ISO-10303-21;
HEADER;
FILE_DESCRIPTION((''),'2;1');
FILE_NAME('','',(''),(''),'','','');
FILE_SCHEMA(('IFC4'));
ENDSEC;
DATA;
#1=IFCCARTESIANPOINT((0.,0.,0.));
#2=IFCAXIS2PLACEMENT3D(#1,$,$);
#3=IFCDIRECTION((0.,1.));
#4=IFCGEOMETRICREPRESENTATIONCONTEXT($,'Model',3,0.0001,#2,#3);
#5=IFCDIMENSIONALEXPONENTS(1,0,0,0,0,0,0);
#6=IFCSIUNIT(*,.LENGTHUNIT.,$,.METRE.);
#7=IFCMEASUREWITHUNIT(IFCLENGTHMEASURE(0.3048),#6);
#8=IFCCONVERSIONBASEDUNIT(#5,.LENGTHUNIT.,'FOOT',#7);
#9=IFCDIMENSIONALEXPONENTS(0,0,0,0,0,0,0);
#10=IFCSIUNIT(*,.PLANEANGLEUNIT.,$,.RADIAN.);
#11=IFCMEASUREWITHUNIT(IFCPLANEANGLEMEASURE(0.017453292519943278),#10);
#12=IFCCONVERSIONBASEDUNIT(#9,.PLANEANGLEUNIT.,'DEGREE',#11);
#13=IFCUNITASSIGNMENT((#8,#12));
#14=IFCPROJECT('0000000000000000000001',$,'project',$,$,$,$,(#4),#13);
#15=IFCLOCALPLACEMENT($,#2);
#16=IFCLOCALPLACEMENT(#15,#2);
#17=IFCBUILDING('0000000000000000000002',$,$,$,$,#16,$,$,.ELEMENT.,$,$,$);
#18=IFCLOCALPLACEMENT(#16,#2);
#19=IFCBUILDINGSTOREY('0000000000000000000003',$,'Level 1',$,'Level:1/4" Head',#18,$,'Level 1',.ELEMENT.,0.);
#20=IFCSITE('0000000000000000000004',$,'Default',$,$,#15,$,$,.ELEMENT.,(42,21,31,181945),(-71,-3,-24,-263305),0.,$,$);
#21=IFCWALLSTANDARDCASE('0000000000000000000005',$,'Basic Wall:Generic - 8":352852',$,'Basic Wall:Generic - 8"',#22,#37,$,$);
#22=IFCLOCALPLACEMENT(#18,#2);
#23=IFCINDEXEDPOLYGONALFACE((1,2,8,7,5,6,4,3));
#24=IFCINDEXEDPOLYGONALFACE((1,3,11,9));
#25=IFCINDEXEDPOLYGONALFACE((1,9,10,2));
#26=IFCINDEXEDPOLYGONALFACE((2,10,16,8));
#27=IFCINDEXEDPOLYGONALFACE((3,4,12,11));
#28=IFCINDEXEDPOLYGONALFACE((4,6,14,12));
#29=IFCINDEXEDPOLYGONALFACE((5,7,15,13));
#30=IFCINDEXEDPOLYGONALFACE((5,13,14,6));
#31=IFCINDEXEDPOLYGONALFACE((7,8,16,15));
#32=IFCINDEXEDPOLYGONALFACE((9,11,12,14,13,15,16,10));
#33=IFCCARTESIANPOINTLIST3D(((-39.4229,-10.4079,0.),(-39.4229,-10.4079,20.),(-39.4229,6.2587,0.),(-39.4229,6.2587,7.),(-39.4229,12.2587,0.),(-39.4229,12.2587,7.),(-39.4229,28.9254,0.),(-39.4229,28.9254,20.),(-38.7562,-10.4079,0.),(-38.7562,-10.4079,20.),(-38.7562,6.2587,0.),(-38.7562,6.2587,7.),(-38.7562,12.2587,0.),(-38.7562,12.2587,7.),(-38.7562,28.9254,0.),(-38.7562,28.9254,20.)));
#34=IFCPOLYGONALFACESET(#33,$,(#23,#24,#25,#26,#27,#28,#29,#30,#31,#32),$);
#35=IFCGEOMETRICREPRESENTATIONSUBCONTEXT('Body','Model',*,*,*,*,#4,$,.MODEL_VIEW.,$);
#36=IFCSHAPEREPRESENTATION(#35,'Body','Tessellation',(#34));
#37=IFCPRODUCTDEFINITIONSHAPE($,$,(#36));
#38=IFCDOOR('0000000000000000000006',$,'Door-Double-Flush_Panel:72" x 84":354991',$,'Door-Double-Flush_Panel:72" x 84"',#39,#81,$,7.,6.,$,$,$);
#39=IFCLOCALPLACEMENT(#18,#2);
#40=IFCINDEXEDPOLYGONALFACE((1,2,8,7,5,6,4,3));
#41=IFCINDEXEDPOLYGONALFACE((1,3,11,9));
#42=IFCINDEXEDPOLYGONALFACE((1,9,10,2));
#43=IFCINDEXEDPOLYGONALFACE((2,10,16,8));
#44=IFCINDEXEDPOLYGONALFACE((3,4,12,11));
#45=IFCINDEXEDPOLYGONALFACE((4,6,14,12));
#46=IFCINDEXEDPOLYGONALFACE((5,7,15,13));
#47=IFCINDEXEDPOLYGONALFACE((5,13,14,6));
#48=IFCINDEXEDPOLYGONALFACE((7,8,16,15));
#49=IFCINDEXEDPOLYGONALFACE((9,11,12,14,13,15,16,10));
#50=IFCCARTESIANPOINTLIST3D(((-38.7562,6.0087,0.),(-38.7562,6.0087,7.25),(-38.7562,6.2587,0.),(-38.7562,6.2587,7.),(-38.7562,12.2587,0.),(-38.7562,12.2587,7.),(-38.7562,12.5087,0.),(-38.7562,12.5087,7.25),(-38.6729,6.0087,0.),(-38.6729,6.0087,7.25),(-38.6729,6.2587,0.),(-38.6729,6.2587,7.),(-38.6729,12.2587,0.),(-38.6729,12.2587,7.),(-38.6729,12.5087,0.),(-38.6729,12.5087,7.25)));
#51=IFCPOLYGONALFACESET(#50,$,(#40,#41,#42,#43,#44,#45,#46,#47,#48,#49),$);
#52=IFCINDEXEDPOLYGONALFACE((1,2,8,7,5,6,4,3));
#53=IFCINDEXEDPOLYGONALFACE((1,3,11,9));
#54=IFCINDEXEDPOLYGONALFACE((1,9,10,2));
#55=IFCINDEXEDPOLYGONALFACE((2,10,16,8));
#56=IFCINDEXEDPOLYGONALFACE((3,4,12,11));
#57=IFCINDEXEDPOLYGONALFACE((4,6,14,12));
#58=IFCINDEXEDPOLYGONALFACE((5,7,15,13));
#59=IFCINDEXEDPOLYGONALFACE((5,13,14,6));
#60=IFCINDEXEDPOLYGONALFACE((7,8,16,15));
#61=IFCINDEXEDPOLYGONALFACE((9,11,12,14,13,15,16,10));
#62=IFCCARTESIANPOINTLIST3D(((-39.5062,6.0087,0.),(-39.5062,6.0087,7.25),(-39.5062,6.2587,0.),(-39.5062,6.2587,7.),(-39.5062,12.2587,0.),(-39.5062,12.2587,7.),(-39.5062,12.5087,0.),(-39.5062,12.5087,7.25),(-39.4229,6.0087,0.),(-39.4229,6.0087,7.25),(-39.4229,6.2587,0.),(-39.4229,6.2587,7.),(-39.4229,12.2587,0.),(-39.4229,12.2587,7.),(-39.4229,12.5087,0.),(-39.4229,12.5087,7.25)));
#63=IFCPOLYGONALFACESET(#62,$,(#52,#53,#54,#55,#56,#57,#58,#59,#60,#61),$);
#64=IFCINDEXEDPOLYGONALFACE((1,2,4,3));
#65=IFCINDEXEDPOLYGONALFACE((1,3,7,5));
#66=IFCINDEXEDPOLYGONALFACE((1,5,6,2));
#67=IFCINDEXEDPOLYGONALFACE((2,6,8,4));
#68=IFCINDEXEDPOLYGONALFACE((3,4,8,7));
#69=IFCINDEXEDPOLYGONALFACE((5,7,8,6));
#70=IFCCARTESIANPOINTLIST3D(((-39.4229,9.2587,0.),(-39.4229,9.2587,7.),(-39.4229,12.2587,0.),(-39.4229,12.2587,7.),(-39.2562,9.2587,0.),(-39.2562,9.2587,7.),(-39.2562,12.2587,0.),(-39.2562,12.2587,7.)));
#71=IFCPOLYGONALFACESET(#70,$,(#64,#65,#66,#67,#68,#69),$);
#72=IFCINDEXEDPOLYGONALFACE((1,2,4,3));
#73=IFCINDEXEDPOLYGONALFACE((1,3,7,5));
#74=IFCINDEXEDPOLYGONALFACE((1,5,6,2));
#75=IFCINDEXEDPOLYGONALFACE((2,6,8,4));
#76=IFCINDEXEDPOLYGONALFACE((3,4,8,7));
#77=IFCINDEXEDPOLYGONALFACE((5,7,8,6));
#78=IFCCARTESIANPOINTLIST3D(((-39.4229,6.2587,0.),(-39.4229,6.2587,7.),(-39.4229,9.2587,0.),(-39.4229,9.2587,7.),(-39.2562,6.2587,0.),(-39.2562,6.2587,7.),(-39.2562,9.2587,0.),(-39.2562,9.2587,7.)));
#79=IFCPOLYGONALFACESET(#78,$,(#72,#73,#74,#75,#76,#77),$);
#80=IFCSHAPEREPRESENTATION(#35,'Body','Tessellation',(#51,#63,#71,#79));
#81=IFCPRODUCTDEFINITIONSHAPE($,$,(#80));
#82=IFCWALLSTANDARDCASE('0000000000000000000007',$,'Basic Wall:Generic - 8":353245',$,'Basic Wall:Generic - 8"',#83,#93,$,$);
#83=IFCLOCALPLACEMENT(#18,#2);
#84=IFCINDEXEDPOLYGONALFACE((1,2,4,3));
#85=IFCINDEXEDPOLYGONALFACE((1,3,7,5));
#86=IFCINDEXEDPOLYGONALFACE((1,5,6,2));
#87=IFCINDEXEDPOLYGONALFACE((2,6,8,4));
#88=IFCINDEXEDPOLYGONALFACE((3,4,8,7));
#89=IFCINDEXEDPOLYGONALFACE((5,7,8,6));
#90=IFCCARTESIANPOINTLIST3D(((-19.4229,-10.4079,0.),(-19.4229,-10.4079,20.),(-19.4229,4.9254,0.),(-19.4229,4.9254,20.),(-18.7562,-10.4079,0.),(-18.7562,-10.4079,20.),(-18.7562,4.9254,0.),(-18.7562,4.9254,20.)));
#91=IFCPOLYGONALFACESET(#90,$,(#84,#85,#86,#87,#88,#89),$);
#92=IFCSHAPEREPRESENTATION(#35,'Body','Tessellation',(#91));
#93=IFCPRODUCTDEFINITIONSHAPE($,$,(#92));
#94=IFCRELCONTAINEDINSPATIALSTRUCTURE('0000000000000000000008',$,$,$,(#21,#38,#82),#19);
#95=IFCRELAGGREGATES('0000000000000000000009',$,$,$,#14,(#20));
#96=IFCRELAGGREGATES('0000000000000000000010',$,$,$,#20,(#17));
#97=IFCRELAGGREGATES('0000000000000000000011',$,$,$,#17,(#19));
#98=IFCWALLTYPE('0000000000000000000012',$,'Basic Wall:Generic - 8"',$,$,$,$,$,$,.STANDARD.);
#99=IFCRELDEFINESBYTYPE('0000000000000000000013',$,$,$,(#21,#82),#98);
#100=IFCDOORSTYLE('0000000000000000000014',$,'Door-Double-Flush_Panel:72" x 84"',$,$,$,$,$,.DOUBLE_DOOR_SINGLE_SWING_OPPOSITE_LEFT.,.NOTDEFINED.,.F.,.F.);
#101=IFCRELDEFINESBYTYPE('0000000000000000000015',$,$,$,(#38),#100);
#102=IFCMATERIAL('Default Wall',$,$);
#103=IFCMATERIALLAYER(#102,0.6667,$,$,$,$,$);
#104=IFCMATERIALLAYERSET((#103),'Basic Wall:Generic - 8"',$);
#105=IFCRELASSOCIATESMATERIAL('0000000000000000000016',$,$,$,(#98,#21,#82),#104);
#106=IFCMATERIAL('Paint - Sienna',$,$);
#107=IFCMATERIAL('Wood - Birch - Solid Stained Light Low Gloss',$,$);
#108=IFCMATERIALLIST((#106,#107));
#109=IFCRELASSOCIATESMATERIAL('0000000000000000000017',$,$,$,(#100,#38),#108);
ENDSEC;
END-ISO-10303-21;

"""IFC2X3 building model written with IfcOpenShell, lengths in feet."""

from ifc_helpers import new_model, entity, si_unit, converted_unit, direction, frame, frame_2d, origin, place, context, subcontext, project, spatial, polyline, rectangle, outline, extrude, source, transform, mapped, material, material_list, layer, layer_set, layer_usage, type_object, type_shapes, element, fill, save


model = new_model("IFC2X3")

# Units and contexts
model_context = context("Model", 3, precision=0.0001, world=origin(), true_north=direction((0.0, 1.0)))
body_context = subcontext(model_context, "Body", "Model", "MODEL_VIEW")
ifc_project = project(units=[converted_unit("LENGTHUNIT", "FOOT", entity("IfcLengthMeasure", 0.3048), si_unit("LENGTHUNIT", "METRE"), dimensions=[1, 0, 0, 0, 0, 0, 0]), converted_unit("PLANEANGLEUNIT", "DEGREE", entity("IfcPlaneAngleMeasure", 0.017453292519943278), si_unit("PLANEANGLEUNIT", "RADIAN"), dimensions=[0, 0, 0, 0, 0, 0, 0])], contexts=[model_context])

# Site, building, storey
site_placement = place(None, origin())
site = spatial("IfcSite", under=ifc_project, at=site_placement, Name="Default", CompositionType="ELEMENT", RefLatitude=(42, 21, 31, 181945), RefLongitude=(-71, -3, -24, -263305), RefElevation=0.0)
building_placement = place(site_placement, origin())
building = spatial("IfcBuilding", under=site, at=building_placement, CompositionType="ELEMENT")
storey_placement = place(building_placement, origin())
storey = spatial("IfcBuildingStorey", under=building, at=storey_placement, Name="Level 1", ObjectType="Level:1/4\" Head", LongName="Level 1", CompositionType="ELEMENT", Elevation=0.0)

# Shared definitions
ifc_material_1 = material(Name="Default Wall")
ifc_layer = layer(ifc_material_1, 0.6667)
ifc_layer_set = layer_set([ifc_layer], Name="Basic Wall:Generic - 8\"")
ifc_layer_usage = layer_usage(ifc_layer_set, "AXIS2", "NEGATIVE", 0.3333)
wall_type = type_object("IfcWallType", Name="Basic Wall:Generic - 8\"", PredefinedType="STANDARD", material=ifc_layer_set)

# Wall, opening, door
wall_1_placement = place(storey_placement, frame((-39.0895, -10.4079, 0.0), z_axis=(0.0, 0.0, 1.0), x_axis=(0.0, 1.0, 0.0)))
wall_1 = element("IfcWallStandardCase", 1, at=wall_1_placement, inside=storey, type_object=wall_type, material=ifc_layer_usage, Name="Basic Wall:Generic - 8\":352852", ObjectType="Basic Wall:Generic - 8\"", context=body_context, shape_type="SweptSolid", body=[
    extrude(rectangle(XDim=39.3333, YDim=0.6667, at=frame_2d((19.6667, 0.0), x_axis=(-1.0, 0.0))), origin(), (0.0, 0.0, 1.0), 20.0),
])
opening_1_placement = place(wall_1_placement, frame((16.6667, -0.3333, 0.0)))
opening_1 = element("IfcOpeningElement", 2, at=opening_1_placement, cuts=wall_1, ObjectType="Opening", context=body_context, shape_type="SweptSolid", body=[
    extrude(rectangle(XDim=7.0, YDim=6.0, at=frame_2d((3.5, 3.0), x_axis=(1.0, 0.0))), frame((0.0, 0.0, 0.0), z_axis=(0.0, 1.0, 0.0), x_axis=(0.0, 0.0, 1.0)), (0.0, 0.0, 1.0), 0.6667),
])
ifc_material_2 = material(Name="Paint - Sienna")
ifc_material_3 = material(Name="Wood - Birch - Solid Stained Light Low Gloss")
ifc_material_list_1 = material_list([ifc_material_2, ifc_material_3])
door_style_1 = type_object("IfcDoorStyle", Name="Door-Double-Flush_Panel:72\" x 84\"", ConstructionType="NOTDEFINED", OperationType="DOUBLE_DOOR_SINGLE_SWING_OPPOSITE_LEFT", ParameterTakesPrecedence=False, Sizeable=False, material=ifc_material_list_1)
shared_shape_1 = source(origin(), body_context, "Body", "SweptSolid", [
    extrude(outline(polyline([(-3.4375, 3.0), (3.5625, 3.0), (3.5625, 3.25), (-3.6875, 3.25), (-3.6875, -3.25), (3.5625, -3.25), (3.5625, -3.0), (-3.4375, -3.0), (-3.4375, 3.0)])), frame((3.0, -0.0833, 3.5625), z_axis=(0.0, 1.0, 0.0), x_axis=(0.0, 0.0, -1.0)), (0.0, 0.0, 1.0), 0.0833),
    extrude(outline(polyline([(-3.4375, 3.0), (3.5625, 3.0), (3.5625, 3.25), (-3.6875, 3.25), (-3.6875, -3.25), (3.5625, -3.25), (3.5625, -3.0), (-3.4375, -3.0), (-3.4375, 3.0)])), frame((3.0, 0.6667, 3.5625), z_axis=(0.0, 1.0, 0.0), x_axis=(0.0, 0.0, -1.0)), (0.0, 0.0, 1.0), 0.0833),
    extrude(rectangle(XDim=0.1667, YDim=3.0, at=frame_2d((0.0, 0.0), x_axis=(1.0, 0.0))), frame((4.5, 0.5833, 0.0), z_axis=(0.0, 0.0, 1.0), x_axis=(0.0, -1.0, 0.0)), (0.0, 0.0, 1.0), 7.0),
    extrude(rectangle(XDim=0.1667, YDim=3.0, at=frame_2d((0.0, 0.0), x_axis=(1.0, 0.0))), frame((1.5, 0.5833, 0.0), z_axis=(0.0, 0.0, 1.0), x_axis=(0.0, -1.0, 0.0)), (0.0, 0.0, 1.0), 7.0),
])
type_shapes(door_style_1, [shared_shape_1])
door_1_placement = place(opening_1_placement, origin())
door_1 = element("IfcDoor", 3, at=door_1_placement, inside=storey, type_object=door_style_1, material=ifc_material_list_1, Name="Door-Double-Flush_Panel:72\" x 84\":354991", ObjectType="Door-Double-Flush_Panel:72\" x 84\"", OverallHeight=7.0, OverallWidth=6.0, context=body_context, shape_type="MappedRepresentation", body=[
    mapped(shared_shape_1, transform((0.0, 0.0, 0.0), scale=1.0)),
])
fill(opening_1, door_1)

# Wall
wall_2_placement = place(storey_placement, frame((-19.0895, 4.9254, 0.0), z_axis=(0.0, 0.0, 1.0), x_axis=(0.0, -1.0, 0.0)))
element("IfcWallStandardCase", 4, at=wall_2_placement, inside=storey, type_object=wall_type, material=ifc_layer_usage, Name="Basic Wall:Generic - 8\":353245", ObjectType="Basic Wall:Generic - 8\"", context=body_context, shape_type="SweptSolid", body=[
    extrude(rectangle(XDim=15.3333, YDim=0.6667, at=frame_2d((7.6667, 0.0), x_axis=(-1.0, 0.0))), origin(), (0.0, 0.0, 1.0), 20.0),
])

save(model, "model.ifc")
